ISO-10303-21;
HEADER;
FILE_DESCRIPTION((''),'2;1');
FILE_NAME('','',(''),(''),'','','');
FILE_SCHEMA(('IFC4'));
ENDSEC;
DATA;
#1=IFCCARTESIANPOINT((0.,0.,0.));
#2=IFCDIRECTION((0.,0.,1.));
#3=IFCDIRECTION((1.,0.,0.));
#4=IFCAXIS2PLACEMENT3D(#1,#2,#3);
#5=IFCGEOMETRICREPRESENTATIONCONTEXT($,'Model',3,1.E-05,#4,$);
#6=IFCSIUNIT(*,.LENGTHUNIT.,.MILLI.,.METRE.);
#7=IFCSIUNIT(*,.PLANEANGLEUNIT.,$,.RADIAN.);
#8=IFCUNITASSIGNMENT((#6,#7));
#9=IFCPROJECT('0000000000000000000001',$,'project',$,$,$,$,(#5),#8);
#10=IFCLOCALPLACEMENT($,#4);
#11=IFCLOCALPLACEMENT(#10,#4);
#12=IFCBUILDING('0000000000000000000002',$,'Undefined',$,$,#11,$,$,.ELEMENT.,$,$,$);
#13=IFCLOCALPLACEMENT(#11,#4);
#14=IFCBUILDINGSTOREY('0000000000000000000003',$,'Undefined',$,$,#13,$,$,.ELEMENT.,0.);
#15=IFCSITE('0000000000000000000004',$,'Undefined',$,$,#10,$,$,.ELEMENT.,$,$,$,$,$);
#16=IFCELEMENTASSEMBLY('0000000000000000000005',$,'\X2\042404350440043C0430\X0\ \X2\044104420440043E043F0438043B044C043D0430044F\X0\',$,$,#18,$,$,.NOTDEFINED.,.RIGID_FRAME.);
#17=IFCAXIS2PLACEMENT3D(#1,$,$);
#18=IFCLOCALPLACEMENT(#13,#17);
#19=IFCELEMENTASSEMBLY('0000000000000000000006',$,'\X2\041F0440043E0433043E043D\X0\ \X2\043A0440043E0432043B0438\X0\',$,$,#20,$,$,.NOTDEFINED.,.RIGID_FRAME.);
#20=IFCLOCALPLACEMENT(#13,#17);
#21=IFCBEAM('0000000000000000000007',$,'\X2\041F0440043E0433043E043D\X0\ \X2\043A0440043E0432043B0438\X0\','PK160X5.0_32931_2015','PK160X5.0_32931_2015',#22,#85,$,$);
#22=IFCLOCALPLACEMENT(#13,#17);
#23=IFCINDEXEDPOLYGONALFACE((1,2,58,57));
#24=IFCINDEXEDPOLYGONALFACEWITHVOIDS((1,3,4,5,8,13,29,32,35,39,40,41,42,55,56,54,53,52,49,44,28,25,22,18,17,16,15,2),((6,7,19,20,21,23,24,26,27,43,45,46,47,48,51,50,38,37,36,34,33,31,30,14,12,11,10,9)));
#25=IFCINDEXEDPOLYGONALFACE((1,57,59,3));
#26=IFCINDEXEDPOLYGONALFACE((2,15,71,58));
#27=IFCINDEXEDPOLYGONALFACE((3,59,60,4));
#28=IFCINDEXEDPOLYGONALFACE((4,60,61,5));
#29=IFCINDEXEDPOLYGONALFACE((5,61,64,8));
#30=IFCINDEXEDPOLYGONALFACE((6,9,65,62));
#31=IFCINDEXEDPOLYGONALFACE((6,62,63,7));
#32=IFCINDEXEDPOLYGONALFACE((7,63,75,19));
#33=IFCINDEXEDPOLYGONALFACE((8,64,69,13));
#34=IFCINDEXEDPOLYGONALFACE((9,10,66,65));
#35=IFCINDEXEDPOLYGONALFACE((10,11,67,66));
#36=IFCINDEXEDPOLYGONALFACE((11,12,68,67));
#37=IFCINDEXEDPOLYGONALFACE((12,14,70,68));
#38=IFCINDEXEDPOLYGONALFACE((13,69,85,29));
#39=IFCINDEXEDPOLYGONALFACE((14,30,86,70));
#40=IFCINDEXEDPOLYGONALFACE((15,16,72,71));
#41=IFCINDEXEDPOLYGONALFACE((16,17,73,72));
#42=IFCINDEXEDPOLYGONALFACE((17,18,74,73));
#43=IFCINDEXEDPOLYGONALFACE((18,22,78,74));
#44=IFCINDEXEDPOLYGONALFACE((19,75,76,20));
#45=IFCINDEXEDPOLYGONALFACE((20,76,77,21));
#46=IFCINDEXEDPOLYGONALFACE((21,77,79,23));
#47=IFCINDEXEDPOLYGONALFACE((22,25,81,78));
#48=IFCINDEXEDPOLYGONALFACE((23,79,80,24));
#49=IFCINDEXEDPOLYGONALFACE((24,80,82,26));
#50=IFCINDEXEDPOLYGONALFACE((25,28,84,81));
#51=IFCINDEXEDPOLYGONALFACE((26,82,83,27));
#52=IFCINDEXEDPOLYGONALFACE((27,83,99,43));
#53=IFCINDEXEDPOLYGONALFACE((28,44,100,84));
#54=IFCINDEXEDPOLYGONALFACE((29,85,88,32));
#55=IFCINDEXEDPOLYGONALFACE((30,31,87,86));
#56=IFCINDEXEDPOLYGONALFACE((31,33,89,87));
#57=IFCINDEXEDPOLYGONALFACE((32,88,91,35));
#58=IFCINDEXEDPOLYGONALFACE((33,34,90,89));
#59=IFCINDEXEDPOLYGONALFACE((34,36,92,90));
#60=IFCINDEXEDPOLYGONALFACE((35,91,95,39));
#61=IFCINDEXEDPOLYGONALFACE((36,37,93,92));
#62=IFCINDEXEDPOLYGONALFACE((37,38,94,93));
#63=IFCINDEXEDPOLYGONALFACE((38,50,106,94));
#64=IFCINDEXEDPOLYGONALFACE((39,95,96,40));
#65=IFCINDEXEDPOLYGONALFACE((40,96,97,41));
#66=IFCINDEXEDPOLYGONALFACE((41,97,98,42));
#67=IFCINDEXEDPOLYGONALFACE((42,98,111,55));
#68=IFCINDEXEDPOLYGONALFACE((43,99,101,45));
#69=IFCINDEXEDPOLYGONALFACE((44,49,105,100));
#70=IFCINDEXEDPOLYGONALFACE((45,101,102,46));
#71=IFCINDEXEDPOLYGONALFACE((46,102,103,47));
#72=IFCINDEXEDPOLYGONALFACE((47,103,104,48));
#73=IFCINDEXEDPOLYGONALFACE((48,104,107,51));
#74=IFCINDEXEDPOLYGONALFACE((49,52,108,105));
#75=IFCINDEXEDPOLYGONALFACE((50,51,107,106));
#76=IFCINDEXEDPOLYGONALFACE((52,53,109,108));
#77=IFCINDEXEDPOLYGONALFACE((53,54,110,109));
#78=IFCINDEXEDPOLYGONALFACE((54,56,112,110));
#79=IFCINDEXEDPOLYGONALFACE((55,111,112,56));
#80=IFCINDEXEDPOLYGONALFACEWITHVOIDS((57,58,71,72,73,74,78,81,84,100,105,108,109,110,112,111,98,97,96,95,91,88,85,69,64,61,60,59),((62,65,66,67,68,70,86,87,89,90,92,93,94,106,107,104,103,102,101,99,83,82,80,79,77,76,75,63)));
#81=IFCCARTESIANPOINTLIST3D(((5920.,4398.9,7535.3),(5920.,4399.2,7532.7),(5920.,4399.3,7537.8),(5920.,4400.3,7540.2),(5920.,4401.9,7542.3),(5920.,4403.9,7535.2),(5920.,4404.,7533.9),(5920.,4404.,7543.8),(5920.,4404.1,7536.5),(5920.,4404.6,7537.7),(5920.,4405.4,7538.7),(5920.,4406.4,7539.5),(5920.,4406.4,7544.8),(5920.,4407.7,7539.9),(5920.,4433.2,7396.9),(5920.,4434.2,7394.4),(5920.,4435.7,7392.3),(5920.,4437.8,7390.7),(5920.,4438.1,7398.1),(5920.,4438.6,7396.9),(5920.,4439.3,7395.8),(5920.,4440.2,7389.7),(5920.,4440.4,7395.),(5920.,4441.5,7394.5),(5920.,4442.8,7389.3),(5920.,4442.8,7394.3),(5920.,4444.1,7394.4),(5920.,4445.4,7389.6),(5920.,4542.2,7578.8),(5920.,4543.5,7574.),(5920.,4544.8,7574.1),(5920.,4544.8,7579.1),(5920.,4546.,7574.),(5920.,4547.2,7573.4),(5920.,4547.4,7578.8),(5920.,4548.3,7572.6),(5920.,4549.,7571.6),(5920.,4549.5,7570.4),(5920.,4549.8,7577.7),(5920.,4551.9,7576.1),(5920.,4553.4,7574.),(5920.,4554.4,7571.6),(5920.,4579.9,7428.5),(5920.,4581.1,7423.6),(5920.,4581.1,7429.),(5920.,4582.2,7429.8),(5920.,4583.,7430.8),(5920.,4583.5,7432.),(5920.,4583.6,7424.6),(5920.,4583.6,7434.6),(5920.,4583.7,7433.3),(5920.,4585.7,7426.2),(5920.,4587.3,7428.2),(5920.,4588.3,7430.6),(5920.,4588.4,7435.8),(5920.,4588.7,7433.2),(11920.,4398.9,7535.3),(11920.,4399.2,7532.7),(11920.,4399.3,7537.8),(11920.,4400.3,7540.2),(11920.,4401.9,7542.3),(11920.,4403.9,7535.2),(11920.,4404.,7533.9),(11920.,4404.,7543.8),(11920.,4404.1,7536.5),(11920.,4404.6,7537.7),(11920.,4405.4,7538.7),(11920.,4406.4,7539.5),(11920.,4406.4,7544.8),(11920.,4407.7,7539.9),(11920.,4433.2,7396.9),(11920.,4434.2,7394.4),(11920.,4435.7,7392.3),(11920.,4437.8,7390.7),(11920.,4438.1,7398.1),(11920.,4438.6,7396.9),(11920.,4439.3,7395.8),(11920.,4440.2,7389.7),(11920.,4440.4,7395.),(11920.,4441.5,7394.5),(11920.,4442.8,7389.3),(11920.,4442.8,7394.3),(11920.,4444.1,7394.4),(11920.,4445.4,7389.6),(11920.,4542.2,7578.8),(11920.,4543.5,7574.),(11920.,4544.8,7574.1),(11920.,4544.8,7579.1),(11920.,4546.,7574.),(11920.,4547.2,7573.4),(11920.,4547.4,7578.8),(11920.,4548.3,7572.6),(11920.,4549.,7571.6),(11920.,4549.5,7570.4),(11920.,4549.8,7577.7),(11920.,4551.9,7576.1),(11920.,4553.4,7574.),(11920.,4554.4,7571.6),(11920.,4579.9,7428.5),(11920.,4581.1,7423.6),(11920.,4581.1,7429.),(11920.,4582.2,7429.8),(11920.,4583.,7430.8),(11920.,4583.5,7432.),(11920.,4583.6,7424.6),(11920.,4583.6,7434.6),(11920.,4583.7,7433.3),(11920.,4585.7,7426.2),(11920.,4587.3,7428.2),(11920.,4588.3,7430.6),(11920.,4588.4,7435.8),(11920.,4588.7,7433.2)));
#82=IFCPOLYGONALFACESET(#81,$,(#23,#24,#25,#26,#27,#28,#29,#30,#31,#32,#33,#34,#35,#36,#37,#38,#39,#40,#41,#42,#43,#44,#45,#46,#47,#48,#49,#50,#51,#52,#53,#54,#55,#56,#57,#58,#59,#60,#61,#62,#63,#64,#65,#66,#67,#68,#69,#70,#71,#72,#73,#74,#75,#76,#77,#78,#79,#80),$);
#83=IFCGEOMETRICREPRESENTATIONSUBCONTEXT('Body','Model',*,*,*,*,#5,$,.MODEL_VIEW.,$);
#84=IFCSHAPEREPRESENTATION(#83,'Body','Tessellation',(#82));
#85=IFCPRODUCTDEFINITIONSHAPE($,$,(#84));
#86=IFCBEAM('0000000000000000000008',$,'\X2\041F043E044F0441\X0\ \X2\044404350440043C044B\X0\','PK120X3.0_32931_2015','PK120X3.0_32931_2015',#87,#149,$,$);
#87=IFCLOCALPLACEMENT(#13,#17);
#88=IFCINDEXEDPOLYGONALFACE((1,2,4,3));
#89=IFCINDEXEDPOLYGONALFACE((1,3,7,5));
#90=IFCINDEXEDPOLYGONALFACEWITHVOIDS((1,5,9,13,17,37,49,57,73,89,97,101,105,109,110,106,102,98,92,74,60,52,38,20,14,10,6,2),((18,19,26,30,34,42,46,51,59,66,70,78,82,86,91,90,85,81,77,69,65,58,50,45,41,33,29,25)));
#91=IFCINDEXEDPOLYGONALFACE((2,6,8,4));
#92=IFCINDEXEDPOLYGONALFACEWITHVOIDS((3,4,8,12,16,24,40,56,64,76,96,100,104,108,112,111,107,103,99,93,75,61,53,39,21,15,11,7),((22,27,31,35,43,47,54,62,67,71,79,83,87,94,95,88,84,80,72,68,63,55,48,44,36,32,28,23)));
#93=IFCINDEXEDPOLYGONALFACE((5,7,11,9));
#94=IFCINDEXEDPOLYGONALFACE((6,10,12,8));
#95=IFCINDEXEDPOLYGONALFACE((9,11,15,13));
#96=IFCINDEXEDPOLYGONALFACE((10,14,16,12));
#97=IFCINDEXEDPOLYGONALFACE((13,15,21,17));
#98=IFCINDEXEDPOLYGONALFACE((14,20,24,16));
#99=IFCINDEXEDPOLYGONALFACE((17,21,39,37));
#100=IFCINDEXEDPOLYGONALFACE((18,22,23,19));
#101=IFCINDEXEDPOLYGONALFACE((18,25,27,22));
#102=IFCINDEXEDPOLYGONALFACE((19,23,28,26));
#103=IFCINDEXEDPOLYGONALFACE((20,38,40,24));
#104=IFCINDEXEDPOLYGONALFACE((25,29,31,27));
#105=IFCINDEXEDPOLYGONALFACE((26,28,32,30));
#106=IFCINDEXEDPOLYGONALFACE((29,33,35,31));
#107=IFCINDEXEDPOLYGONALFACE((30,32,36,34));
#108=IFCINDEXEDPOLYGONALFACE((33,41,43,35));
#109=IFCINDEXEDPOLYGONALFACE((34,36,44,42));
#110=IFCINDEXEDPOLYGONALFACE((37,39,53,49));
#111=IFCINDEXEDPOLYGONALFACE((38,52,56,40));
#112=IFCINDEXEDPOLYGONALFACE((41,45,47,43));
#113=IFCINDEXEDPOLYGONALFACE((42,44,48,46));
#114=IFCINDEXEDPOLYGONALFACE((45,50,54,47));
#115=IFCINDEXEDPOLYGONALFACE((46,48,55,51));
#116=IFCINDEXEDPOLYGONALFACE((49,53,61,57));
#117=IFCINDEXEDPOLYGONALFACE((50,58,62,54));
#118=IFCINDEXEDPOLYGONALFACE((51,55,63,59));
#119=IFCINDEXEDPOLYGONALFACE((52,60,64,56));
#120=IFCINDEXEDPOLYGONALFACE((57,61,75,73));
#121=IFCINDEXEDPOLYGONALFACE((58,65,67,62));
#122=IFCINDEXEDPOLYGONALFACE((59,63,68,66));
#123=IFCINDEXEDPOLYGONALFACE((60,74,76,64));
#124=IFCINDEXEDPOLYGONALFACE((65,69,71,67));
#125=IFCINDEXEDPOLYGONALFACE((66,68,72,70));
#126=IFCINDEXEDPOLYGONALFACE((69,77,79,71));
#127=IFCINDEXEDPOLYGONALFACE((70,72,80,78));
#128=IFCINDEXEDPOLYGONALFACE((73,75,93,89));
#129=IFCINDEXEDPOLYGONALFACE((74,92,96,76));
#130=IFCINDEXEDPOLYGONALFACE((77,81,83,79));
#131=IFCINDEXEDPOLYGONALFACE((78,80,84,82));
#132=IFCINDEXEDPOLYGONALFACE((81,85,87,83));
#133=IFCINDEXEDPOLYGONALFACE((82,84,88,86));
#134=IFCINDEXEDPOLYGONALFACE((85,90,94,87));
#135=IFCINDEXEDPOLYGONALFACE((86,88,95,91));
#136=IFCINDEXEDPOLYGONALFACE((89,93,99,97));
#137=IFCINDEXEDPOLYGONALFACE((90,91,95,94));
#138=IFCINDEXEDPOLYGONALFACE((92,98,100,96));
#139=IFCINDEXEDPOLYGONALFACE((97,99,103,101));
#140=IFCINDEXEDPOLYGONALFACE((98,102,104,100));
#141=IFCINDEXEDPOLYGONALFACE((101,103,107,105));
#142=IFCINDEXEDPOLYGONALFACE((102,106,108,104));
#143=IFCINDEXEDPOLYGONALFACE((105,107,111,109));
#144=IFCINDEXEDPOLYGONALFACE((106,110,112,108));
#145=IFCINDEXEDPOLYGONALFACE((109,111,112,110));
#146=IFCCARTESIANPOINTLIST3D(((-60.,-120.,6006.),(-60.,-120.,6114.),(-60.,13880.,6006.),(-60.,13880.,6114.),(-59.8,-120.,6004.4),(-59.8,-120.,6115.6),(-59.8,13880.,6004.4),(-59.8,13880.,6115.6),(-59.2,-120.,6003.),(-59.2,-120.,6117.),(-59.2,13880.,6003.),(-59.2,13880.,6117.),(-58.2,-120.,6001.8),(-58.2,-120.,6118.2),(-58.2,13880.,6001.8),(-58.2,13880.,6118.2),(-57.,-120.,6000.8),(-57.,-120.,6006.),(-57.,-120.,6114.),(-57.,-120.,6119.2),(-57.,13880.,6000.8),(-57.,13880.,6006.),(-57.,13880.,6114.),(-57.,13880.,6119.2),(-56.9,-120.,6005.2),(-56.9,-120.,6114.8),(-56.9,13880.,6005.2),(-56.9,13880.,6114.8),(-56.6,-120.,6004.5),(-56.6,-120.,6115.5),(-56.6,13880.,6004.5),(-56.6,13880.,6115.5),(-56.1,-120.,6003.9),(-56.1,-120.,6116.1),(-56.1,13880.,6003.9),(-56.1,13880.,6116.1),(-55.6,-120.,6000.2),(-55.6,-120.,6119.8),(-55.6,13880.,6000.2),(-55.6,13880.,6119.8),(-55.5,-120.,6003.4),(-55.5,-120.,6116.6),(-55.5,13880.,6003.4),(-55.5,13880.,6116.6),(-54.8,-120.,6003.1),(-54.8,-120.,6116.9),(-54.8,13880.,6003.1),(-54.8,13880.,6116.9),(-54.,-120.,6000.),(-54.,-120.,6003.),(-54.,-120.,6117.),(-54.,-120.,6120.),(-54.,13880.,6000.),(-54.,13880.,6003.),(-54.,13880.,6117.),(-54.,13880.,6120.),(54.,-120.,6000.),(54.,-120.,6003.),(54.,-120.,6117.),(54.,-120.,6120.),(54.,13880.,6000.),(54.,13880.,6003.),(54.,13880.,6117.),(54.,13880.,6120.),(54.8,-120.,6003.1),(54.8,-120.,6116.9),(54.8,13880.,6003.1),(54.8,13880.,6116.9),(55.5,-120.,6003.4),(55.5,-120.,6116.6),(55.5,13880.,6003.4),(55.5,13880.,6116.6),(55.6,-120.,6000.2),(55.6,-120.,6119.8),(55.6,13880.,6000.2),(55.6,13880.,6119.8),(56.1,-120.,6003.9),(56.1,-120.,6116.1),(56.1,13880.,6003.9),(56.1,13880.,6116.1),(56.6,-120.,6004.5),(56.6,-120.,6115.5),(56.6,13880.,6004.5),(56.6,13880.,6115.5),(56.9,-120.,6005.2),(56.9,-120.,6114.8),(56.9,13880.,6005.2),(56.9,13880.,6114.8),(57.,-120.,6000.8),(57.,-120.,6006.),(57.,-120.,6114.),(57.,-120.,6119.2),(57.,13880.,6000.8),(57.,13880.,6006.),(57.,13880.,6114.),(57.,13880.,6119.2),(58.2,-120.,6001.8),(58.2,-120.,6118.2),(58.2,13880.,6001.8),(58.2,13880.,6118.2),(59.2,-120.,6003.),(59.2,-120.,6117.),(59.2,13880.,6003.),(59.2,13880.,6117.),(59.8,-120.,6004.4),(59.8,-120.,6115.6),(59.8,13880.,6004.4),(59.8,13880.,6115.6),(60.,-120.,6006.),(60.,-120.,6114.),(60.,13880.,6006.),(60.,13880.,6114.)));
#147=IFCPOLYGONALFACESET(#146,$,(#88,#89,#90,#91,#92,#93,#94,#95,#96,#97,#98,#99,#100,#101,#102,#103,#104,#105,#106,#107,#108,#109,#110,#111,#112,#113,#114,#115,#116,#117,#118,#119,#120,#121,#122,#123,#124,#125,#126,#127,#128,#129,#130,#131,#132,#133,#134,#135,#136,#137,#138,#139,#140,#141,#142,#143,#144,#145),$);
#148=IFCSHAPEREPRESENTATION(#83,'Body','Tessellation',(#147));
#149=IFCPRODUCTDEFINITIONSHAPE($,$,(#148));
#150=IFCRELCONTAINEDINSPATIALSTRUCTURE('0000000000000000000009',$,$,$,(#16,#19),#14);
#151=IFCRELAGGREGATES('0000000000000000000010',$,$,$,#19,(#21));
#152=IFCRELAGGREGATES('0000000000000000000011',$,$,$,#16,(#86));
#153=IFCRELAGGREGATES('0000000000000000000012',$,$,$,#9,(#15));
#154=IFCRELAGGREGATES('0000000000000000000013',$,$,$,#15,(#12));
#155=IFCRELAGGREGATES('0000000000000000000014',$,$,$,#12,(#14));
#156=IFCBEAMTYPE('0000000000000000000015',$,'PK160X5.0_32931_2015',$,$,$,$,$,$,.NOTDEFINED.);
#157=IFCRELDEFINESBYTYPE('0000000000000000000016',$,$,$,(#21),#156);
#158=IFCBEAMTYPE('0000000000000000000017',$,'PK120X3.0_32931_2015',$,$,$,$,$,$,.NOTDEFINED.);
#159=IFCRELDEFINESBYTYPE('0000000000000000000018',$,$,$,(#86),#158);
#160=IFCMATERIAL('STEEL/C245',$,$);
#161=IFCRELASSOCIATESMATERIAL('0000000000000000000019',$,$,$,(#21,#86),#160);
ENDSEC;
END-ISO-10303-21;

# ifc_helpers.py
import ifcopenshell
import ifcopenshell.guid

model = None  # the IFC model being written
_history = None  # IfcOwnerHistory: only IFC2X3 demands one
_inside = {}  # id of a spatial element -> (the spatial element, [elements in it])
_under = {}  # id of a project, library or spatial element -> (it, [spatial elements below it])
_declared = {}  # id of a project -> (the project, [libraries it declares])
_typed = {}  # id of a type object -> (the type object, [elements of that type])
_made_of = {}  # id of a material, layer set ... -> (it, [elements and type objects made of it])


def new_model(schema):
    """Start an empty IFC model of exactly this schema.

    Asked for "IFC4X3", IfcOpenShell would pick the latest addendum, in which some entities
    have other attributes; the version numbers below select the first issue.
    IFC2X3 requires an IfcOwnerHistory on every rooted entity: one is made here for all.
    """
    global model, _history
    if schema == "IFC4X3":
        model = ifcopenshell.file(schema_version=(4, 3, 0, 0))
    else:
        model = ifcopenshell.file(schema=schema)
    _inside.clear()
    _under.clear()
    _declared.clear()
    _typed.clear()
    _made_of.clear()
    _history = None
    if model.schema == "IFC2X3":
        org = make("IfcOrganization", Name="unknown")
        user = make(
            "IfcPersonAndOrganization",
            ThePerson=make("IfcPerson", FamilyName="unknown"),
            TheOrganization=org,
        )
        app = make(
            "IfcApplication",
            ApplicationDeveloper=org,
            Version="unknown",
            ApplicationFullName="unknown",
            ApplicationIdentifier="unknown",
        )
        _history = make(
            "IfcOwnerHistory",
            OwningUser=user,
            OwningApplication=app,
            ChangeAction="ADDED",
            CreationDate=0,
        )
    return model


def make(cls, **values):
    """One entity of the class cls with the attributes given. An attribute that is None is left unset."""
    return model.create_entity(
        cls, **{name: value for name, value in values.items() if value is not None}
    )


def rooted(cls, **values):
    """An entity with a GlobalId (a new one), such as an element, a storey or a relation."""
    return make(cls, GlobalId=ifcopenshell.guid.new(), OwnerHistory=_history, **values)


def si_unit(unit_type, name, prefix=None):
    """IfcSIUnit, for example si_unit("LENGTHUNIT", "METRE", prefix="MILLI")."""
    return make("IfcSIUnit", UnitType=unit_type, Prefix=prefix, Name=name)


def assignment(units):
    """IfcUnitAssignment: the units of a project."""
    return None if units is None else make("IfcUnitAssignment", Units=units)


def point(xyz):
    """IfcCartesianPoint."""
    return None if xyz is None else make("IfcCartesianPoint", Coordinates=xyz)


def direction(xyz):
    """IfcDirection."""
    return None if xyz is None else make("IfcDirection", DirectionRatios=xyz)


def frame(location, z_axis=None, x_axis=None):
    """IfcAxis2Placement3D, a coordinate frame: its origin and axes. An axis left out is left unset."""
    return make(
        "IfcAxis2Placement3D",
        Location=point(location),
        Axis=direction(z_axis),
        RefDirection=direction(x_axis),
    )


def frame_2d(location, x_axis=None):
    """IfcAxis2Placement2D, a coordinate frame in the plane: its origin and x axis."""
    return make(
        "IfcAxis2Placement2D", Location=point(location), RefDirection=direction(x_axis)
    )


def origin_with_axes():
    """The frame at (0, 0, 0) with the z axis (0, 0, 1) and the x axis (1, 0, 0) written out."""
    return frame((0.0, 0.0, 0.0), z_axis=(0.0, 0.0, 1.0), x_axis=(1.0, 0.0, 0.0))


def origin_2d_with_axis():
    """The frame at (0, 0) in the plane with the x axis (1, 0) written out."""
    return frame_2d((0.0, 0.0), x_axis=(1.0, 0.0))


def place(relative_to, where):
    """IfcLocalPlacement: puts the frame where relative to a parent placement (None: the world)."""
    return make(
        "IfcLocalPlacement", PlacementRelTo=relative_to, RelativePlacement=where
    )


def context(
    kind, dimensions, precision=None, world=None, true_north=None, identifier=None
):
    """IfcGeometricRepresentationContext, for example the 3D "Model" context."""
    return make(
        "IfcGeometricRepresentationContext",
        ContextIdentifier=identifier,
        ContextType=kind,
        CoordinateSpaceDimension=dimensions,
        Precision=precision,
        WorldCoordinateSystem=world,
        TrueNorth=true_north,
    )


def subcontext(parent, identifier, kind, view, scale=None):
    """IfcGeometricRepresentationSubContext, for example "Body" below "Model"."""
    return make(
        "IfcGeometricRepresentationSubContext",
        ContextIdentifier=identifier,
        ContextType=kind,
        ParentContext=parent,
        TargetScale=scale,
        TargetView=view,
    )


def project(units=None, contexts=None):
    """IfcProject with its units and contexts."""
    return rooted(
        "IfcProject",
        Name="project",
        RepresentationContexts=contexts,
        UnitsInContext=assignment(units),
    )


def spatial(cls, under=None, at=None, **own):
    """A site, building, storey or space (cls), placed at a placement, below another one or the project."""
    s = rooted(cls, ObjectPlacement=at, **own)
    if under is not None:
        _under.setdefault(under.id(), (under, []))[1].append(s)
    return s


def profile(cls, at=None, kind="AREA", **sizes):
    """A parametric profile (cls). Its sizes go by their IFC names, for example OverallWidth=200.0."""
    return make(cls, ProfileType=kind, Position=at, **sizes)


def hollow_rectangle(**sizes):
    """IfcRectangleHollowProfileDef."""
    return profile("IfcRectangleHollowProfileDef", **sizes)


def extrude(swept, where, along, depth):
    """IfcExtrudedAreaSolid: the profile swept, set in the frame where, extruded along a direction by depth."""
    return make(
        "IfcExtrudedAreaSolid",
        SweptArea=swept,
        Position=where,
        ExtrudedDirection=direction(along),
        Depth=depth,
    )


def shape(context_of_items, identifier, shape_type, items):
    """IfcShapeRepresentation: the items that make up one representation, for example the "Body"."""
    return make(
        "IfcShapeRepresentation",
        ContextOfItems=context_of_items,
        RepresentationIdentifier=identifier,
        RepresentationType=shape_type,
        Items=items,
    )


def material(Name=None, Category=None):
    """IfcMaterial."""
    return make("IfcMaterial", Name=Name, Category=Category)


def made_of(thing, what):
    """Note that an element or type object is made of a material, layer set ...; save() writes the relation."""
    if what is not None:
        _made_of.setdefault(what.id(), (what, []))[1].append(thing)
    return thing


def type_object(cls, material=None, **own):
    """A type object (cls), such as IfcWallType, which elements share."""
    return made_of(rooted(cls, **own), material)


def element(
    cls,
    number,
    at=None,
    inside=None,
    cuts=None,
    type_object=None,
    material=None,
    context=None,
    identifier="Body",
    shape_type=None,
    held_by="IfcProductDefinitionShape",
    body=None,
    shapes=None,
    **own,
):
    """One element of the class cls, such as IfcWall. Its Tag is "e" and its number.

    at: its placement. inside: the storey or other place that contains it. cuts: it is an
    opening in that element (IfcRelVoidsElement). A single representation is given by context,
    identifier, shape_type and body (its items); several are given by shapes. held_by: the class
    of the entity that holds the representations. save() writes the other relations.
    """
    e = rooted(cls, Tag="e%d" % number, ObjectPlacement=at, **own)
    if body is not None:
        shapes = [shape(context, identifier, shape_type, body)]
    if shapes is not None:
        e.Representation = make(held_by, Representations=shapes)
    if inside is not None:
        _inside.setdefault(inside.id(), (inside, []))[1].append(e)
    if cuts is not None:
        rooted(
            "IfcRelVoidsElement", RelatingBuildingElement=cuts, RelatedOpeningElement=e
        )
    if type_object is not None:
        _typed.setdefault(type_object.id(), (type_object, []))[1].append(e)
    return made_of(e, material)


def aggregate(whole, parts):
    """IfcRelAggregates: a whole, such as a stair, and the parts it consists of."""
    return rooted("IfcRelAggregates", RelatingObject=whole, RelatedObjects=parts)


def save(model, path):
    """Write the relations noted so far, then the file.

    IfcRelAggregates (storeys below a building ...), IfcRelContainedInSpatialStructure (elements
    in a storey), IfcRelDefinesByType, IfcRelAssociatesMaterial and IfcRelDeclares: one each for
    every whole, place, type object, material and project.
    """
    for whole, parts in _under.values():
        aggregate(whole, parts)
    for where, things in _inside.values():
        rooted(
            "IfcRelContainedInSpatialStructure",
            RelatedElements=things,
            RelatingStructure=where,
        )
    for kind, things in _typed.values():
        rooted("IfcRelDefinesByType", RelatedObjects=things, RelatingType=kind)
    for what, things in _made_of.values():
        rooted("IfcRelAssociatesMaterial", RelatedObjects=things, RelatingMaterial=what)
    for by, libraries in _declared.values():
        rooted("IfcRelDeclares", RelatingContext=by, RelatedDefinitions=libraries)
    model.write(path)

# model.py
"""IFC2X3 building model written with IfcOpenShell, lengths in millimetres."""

from ifc_helpers import new_model, si_unit, frame, origin_with_axes, origin_2d_with_axis, place, context, subcontext, project, spatial, hollow_rectangle, extrude, material, type_object, element, aggregate, save


model = new_model("IFC2X3")

# Units and contexts
model_context = context("Model", 3, precision=1e-05, world=origin_with_axes())
body_context = subcontext(model_context, "Body", "Model", "MODEL_VIEW")
ifc_project = project(units=[si_unit("LENGTHUNIT", "METRE", prefix="MILLI"), si_unit("PLANEANGLEUNIT", "RADIAN")], contexts=[model_context])

# Site, building, storey
site_placement = place(None, origin_with_axes())
site = spatial("IfcSite", under=ifc_project, at=site_placement, Name="Undefined", CompositionType="ELEMENT")
building_placement = place(site_placement, origin_with_axes())
building = spatial("IfcBuilding", under=site, at=building_placement, Name="Undefined", CompositionType="ELEMENT")
storey_placement = place(building_placement, origin_with_axes())
storey = spatial("IfcBuildingStorey", under=building, at=storey_placement, Name="Undefined", CompositionType="ELEMENT", Elevation=0.0)

# Shared definitions
ifc_material = material(Name="STEEL/C245")

# Element assembly
assembly_1_placement = place(storey_placement, origin_with_axes())
assembly_1 = element("IfcElementAssembly", 1, at=assembly_1_placement, inside=storey, Name="Ферма стропильная", AssemblyPlace="NOTDEFINED", PredefinedType="RIGID_FRAME")

# Element assembly, beam
beam_type_1 = type_object("IfcBeamType", Name="PK160X5.0_32931_2015", PredefinedType="NOTDEFINED")
assembly_2_placement = place(storey_placement, origin_with_axes())
assembly_2 = element("IfcElementAssembly", 2, at=assembly_2_placement, inside=storey, Name="Прогон кровли", AssemblyPlace="NOTDEFINED", PredefinedType="RIGID_FRAME")
beam_1_placement = place(assembly_2_placement, frame((5920.0, 4493.8, 7484.2), z_axis=(0.0, -0.243188, 0.969979), x_axis=(1.0, 0.0, 0.0)))
beam_1 = element("IfcBeam", 3, at=beam_1_placement, type_object=beam_type_1, material=ifc_material, Name="Прогон кровли", Description="PK160X5.0_32931_2015", ObjectType="PK160X5.0_32931_2015", context=body_context, shape_type="SweptSolid", body=[
    extrude(hollow_rectangle(XDim=160.0, YDim=160.0, WallThickness=5.0, InnerFilletRadius=5.0, OuterFilletRadius=10.0, at=origin_2d_with_axis()), frame((6000.0, 0.0, 0.0), z_axis=(-1.0, 0.0, 0.0), x_axis=(0.0, -1.0, 0.0)), (0.0, 0.0, 1.0), 6000.0),
])
aggregate(assembly_2, [beam_1])

# Beam
beam_type_2 = type_object("IfcBeamType", Name="PK120X3.0_32931_2015", PredefinedType="NOTDEFINED")
beam_2_placement = place(assembly_1_placement, frame((0.0, -120.0, 6060.0), z_axis=(0.0, 0.0, 1.0), x_axis=(0.0, 1.0, 0.0)))
beam_2 = element("IfcBeam", 4, at=beam_2_placement, type_object=beam_type_2, material=ifc_material, Name="Пояс фермы", Description="PK120X3.0_32931_2015", ObjectType="PK120X3.0_32931_2015", context=body_context, shape_type="SweptSolid", body=[
    extrude(hollow_rectangle(XDim=120.0, YDim=120.0, WallThickness=3.0, InnerFilletRadius=3.0, OuterFilletRadius=6.0, at=origin_2d_with_axis()), frame((14000.0, 0.0, 0.0), z_axis=(-1.0, 0.0, 0.0), x_axis=(0.0, -1.0, 0.0)), (0.0, 0.0, 1.0), 14000.0),
])
aggregate(assembly_1, [beam_2])

save(model, "model.ifc")
